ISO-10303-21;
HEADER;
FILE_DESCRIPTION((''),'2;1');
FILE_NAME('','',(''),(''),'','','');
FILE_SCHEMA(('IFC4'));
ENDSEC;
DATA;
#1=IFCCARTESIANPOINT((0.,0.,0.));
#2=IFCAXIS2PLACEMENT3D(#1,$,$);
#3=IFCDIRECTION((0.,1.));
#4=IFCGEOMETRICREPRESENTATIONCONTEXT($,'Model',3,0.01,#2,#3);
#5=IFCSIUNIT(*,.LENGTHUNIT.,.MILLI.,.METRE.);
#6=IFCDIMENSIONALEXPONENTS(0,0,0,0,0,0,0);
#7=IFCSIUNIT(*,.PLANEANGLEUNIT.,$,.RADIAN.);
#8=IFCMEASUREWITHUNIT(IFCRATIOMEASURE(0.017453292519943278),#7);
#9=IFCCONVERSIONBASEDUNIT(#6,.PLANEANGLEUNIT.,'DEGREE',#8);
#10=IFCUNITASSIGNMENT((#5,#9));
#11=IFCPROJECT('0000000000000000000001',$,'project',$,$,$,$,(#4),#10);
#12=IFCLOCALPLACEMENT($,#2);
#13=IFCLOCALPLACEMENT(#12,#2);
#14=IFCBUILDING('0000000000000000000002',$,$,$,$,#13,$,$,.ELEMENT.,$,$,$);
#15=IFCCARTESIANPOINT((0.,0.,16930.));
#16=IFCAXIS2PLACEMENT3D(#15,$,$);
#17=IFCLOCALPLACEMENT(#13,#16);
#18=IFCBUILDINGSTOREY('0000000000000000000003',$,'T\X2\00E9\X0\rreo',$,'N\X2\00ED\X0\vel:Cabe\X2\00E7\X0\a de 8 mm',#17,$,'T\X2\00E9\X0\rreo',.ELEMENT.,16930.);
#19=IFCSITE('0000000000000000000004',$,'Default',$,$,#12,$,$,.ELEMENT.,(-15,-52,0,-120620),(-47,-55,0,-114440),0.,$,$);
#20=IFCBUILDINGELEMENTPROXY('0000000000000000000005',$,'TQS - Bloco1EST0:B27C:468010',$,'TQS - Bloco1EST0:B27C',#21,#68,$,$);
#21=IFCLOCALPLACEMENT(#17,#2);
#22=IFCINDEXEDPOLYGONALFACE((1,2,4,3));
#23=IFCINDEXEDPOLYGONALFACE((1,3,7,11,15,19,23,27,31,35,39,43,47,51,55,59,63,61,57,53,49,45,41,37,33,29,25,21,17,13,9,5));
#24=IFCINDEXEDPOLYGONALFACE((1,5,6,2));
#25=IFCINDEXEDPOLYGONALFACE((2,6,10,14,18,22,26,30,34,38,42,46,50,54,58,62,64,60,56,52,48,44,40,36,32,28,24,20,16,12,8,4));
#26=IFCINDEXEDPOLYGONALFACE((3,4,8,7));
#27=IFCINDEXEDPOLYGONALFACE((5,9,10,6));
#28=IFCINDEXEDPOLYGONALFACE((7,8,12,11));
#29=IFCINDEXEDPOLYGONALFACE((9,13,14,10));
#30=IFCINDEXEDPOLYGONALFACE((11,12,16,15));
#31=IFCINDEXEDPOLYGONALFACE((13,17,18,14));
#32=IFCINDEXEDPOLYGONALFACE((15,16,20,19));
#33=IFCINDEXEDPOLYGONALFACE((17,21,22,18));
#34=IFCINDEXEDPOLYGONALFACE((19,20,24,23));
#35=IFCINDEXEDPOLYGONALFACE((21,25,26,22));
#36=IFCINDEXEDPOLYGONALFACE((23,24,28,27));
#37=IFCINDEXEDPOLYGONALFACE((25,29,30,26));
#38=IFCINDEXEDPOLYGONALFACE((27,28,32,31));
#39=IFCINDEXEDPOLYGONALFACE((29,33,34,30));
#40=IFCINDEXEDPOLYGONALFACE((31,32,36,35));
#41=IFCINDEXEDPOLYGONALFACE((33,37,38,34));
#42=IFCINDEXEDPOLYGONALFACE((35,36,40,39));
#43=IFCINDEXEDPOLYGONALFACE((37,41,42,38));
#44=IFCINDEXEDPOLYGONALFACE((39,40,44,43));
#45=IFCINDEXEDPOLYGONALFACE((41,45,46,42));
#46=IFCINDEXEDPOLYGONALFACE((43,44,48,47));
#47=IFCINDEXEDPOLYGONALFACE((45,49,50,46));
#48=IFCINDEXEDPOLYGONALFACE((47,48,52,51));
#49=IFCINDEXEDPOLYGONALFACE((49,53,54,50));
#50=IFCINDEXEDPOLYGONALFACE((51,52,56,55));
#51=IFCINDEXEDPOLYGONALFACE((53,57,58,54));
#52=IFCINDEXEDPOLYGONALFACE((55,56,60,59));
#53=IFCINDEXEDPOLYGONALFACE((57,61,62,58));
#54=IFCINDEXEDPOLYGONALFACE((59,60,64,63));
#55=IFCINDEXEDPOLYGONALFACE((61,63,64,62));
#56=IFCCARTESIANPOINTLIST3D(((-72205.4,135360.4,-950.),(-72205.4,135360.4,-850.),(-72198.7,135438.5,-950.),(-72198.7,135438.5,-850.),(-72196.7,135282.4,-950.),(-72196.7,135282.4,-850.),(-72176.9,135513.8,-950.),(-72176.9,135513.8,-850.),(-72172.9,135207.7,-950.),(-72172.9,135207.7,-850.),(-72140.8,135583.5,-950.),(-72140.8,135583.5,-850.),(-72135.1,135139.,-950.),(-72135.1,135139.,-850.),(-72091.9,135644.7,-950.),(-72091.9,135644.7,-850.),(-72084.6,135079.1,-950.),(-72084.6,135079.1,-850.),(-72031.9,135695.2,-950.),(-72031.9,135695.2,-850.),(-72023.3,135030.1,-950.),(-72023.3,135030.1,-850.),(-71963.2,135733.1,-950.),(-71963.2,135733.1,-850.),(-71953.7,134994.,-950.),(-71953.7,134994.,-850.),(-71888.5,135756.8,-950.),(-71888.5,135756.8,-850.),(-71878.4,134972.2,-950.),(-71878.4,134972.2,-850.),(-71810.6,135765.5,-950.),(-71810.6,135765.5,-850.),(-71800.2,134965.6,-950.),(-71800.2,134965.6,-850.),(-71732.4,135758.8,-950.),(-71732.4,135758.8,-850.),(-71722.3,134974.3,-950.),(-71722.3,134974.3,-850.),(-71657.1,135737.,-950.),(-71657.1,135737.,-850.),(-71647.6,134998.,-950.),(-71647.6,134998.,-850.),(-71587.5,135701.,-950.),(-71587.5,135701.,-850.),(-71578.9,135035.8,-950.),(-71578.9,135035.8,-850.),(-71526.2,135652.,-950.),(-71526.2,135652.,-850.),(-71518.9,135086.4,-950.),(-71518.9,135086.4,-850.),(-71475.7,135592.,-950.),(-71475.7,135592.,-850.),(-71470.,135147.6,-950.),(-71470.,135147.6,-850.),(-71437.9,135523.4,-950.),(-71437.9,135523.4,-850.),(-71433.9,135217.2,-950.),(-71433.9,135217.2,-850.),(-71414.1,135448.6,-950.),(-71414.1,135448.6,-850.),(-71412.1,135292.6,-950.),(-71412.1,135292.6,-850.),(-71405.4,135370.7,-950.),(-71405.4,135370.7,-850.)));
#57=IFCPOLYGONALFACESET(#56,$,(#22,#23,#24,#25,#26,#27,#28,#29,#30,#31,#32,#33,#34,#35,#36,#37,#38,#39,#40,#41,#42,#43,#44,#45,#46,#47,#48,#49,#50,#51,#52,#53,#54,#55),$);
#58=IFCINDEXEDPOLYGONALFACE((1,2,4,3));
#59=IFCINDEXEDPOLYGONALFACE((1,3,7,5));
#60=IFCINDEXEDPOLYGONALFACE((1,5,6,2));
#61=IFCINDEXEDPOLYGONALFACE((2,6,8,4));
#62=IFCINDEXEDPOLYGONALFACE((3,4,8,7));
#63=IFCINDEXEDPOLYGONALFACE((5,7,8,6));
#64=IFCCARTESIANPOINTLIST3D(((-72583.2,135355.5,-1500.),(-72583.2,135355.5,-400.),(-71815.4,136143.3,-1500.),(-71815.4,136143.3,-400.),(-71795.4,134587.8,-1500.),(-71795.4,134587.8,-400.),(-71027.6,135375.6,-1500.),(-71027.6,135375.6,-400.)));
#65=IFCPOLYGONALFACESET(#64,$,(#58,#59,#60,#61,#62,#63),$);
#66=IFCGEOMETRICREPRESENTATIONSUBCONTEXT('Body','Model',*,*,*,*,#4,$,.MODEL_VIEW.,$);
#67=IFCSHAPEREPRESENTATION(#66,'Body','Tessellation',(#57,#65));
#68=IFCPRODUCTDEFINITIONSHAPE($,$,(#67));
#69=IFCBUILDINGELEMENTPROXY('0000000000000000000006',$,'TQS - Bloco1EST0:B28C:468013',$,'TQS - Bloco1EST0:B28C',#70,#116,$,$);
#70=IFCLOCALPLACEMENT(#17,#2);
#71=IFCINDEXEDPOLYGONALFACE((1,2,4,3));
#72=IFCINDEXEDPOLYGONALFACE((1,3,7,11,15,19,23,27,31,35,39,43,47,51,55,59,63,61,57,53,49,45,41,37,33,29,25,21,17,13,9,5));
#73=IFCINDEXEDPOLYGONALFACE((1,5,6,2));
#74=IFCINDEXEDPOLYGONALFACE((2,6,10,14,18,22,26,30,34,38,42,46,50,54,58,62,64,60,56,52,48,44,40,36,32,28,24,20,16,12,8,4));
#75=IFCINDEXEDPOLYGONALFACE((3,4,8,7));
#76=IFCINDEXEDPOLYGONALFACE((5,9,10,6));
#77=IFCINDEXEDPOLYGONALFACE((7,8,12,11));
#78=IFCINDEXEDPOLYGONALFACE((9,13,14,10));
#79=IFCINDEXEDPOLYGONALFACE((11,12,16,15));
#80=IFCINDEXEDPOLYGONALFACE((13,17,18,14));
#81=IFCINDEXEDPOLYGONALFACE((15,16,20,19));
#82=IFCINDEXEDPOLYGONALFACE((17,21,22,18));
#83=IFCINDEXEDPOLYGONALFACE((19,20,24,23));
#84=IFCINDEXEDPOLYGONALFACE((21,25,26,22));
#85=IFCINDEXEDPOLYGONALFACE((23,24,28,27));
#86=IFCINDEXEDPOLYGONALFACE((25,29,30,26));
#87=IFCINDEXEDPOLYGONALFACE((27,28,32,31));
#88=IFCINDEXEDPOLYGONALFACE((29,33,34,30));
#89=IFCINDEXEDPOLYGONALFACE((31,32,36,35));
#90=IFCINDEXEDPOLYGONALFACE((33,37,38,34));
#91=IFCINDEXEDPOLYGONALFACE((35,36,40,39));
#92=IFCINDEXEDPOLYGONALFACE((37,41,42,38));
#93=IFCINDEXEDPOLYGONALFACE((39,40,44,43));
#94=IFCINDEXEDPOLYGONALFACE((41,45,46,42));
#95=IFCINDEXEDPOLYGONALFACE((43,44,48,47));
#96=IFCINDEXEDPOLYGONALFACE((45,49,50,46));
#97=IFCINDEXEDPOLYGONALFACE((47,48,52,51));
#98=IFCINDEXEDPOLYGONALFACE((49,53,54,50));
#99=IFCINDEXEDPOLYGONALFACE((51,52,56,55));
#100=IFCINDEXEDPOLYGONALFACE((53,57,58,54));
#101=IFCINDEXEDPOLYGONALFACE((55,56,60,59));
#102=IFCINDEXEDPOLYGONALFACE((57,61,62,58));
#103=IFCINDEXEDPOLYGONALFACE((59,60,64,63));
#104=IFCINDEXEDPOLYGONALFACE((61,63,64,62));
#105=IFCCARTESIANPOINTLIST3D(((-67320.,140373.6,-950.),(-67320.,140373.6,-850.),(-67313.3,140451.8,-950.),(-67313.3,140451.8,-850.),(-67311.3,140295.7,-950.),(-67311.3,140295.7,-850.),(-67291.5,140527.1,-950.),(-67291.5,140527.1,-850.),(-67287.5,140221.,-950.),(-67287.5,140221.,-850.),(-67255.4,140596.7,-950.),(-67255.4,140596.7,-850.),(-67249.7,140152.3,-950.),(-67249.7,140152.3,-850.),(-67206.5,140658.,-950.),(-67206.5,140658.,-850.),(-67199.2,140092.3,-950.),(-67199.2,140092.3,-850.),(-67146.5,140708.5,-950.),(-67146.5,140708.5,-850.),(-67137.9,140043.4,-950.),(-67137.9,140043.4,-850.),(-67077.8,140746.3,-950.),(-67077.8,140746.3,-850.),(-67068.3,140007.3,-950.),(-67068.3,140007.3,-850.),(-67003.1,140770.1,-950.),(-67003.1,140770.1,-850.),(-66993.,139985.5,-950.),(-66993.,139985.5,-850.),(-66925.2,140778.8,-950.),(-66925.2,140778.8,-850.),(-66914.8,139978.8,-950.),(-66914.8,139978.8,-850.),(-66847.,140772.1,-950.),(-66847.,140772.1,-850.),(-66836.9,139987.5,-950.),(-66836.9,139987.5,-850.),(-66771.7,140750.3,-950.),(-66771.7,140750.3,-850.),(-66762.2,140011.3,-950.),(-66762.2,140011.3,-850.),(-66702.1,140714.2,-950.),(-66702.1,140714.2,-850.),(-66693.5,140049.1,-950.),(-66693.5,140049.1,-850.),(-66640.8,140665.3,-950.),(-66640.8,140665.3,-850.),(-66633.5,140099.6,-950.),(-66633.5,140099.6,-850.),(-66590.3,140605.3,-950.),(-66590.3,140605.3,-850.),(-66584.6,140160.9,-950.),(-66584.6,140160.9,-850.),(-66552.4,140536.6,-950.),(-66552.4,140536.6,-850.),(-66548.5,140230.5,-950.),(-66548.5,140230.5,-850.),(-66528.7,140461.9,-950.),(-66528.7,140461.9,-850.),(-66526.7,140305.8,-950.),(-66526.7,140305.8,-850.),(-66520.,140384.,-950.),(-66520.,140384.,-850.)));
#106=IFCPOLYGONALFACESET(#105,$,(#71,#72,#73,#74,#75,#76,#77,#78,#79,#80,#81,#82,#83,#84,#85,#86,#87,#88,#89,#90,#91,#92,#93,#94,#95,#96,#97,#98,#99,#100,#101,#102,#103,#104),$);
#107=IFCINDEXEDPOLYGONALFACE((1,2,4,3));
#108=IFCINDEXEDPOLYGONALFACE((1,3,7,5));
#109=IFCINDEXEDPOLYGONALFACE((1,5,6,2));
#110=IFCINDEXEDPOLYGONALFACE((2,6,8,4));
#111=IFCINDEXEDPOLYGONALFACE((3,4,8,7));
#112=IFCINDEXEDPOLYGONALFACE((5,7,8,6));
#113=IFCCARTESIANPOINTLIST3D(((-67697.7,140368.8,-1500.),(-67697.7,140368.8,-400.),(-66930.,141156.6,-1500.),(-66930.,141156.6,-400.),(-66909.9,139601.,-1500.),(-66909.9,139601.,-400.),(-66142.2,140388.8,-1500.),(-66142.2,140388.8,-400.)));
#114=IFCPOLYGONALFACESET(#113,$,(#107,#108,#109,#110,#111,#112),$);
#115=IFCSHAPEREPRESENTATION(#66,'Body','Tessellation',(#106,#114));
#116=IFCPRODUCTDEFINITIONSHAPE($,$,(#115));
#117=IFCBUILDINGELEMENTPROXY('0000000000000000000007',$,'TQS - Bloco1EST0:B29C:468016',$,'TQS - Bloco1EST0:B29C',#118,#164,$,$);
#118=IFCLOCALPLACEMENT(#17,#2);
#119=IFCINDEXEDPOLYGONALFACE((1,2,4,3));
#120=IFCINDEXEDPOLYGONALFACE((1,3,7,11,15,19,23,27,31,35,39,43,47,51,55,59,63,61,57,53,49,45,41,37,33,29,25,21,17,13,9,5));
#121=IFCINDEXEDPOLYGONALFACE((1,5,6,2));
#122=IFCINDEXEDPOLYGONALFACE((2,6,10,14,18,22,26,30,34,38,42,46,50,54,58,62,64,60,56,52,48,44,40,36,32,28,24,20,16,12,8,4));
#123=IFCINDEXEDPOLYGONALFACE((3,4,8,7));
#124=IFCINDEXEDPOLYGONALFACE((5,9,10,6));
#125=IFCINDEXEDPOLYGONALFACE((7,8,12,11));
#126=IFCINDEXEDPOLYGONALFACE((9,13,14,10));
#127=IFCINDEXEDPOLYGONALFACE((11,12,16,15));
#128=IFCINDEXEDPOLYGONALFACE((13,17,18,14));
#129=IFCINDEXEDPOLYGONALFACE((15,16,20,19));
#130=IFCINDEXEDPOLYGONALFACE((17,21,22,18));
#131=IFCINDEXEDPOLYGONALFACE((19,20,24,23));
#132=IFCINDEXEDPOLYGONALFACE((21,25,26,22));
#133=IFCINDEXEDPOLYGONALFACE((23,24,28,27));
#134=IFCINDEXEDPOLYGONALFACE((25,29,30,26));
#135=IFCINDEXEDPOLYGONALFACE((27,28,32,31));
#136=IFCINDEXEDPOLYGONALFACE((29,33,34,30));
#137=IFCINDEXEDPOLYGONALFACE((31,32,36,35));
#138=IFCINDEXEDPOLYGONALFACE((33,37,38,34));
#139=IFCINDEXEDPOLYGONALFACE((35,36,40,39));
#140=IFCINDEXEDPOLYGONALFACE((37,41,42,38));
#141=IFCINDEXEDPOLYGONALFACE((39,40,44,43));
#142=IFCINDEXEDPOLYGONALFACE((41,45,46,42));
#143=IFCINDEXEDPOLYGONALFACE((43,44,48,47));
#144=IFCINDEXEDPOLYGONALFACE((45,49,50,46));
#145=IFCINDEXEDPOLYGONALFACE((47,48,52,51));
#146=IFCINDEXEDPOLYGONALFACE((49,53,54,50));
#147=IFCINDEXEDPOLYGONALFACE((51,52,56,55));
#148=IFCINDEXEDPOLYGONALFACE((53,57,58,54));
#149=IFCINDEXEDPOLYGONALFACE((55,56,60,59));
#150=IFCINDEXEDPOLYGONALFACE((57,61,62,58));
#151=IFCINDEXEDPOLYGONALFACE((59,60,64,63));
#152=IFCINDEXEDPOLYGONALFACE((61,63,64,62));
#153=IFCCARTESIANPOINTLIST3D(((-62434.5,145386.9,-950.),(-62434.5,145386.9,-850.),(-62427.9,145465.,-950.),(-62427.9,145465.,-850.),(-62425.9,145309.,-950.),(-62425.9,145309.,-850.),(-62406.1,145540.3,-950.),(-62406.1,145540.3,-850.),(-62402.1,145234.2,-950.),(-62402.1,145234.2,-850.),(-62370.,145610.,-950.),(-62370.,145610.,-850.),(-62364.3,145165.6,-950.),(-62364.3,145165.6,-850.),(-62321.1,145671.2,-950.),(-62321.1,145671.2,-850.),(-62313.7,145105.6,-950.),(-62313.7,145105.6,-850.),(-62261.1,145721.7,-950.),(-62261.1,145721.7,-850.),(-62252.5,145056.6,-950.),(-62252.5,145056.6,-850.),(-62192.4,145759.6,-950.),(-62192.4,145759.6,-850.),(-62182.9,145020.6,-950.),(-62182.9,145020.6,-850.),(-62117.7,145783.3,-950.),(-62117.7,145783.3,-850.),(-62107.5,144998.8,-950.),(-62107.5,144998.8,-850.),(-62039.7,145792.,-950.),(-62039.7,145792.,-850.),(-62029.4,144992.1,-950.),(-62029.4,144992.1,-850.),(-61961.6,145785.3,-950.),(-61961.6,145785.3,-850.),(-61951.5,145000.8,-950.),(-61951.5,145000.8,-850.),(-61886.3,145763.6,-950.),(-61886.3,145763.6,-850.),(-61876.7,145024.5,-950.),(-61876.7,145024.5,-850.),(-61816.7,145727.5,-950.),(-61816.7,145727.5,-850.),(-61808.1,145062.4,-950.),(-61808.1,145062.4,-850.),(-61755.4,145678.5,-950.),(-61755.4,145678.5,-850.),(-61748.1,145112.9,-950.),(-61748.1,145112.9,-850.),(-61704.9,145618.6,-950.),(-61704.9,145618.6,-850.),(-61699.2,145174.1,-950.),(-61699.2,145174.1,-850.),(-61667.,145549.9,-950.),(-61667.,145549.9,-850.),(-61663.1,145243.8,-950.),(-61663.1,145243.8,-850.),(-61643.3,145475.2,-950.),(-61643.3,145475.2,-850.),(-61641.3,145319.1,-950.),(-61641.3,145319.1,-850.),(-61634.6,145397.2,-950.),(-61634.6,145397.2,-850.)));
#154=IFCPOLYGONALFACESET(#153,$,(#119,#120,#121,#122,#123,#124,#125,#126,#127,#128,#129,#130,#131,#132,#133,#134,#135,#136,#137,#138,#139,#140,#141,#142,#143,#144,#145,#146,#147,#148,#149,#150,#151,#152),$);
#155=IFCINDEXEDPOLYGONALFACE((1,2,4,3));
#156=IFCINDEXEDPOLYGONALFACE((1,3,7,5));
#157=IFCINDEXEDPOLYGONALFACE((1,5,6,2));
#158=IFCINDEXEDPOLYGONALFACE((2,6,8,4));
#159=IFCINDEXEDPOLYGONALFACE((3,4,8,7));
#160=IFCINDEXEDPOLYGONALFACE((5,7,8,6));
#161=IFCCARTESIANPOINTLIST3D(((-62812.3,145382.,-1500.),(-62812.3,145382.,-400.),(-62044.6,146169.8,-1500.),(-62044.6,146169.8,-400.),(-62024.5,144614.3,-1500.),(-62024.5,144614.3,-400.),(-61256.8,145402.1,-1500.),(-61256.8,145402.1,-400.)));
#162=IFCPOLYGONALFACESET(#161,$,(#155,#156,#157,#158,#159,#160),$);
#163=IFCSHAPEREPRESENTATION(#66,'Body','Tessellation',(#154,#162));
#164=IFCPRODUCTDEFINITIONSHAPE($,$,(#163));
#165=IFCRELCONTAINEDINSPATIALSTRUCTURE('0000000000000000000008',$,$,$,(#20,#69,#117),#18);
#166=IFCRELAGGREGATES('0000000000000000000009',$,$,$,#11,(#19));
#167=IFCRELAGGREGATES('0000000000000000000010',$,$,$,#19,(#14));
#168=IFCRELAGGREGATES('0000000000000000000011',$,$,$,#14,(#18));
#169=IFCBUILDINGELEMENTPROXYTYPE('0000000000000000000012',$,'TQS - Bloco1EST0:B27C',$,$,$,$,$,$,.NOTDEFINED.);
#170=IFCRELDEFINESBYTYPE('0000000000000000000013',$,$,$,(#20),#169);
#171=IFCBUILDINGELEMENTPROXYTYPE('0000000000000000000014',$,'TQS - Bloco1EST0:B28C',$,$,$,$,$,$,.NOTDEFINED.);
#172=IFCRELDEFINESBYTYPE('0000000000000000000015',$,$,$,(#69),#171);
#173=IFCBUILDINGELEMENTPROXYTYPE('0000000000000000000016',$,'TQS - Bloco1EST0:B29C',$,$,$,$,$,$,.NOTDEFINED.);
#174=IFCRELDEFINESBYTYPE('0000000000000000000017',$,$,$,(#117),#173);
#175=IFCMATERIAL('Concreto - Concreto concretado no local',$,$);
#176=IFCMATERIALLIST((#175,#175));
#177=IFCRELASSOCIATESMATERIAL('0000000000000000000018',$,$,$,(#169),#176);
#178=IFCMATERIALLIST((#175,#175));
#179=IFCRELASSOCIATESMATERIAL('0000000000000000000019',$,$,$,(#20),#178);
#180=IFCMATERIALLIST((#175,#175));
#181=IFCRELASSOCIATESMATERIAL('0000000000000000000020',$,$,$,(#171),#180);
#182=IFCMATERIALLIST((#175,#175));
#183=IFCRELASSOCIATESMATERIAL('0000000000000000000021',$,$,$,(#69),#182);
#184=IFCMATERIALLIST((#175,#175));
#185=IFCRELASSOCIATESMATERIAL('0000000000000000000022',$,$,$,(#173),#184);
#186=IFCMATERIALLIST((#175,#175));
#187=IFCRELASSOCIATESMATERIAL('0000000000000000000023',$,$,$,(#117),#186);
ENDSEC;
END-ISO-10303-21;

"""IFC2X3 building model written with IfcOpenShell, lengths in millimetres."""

from ifc_helpers import new_model, entity, si_unit, converted_unit, direction, frame, frame_2d, origin, origin_2d_with_axis, place, context, subcontext, project, spatial, rectangle, circle, extrude, source, transform, mapped, material, material_list, type_object, type_shapes, element, save


model = new_model("IFC2X3")

# Units and contexts
model_context = context("Model", 3, precision=0.01, world=origin(), true_north=direction((0.0, 1.0)))
body_context = subcontext(model_context, "Body", "Model", "MODEL_VIEW")
ifc_project = project(units=[si_unit("LENGTHUNIT", "METRE", prefix="MILLI"), converted_unit("PLANEANGLEUNIT", "DEGREE", entity("IfcRatioMeasure", 0.017453292519943278), si_unit("PLANEANGLEUNIT", "RADIAN"), dimensions=[0, 0, 0, 0, 0, 0, 0])], contexts=[model_context])

# Site, building, storey
site_placement = place(None, origin())
site = spatial("IfcSite", under=ifc_project, at=site_placement, Name="Default", CompositionType="ELEMENT", RefLatitude=(-15, -52, 0, -120620), RefLongitude=(-47, -55, 0, -114440), RefElevation=0.0)
building_placement = place(site_placement, origin())
building = spatial("IfcBuilding", under=site, at=building_placement, CompositionType="ELEMENT")
storey_placement = place(building_placement, frame((0.0, 0.0, 16930.0)))
storey = spatial("IfcBuildingStorey", under=building, at=storey_placement, Name="Térreo", ObjectType="Nível:Cabeça de 8 mm", LongName="Térreo", CompositionType="ELEMENT", Elevation=16930.0)

# Building element proxies
ifc_material_1 = material(Name="Concreto - Concreto concretado no local")
ifc_material_list_1 = material_list([ifc_material_1, ifc_material_1])
ifc_material_list_2 = material_list([ifc_material_1, ifc_material_1])
building_element_proxy_type_1 = type_object("IfcBuildingElementProxyType", Name="TQS - Bloco1EST0:B27C", PredefinedType="NOTDEFINED", material=ifc_material_list_2)
shared_shape_1 = source(origin(), body_context, "Body", "SweptSolid", [
    extrude(circle(Radius=400.0, at=frame_2d((0.0, 0.0), x_axis=(1.0, 0.0))), frame((0.0, 0.0, -550.0)), (0.0, 0.0, 1.0), 100.0),
    extrude(rectangle(XDim=1100.0, YDim=1100.0, at=origin_2d_with_axis()), frame((0.0, 0.0, -1100.0), z_axis=(0.0, 0.0, 1.0), x_axis=(-1.0, 0.0, 0.0)), (0.0, 0.0, 1.0), 1100.0),
])
type_shapes(building_element_proxy_type_1, [shared_shape_1])
proxy_1_placement = place(storey_placement, frame((-71805.4, 135365.5, -400.0), z_axis=(0.0, 0.0, 1.0), x_axis=(0.697915, 0.71618, 0.0)))
element("IfcBuildingElementProxy", 1, at=proxy_1_placement, inside=storey, type_object=building_element_proxy_type_1, material=ifc_material_list_1, Name="TQS - Bloco1EST0:B27C:468010", ObjectType="TQS - Bloco1EST0:B27C", context=body_context, shape_type="MappedRepresentation", body=[
    mapped(shared_shape_1, transform((0.0, 0.0, 0.0), scale=1.0)),
])
ifc_material_list_3 = material_list([ifc_material_1, ifc_material_1])
ifc_material_list_4 = material_list([ifc_material_1, ifc_material_1])
building_element_proxy_type_2 = type_object("IfcBuildingElementProxyType", Name="TQS - Bloco1EST0:B28C", PredefinedType="NOTDEFINED", material=ifc_material_list_4)
shared_shape_2 = source(origin(), body_context, "Body", "SweptSolid", [
    extrude(circle(Radius=400.0, at=frame_2d((0.0, 0.0), x_axis=(1.0, 0.0))), frame((0.0, 0.0, -550.0)), (0.0, 0.0, 1.0), 100.0),
    extrude(rectangle(XDim=1100.0, YDim=1100.0, at=origin_2d_with_axis()), frame((0.0, 0.0, -1100.0), z_axis=(0.0, 0.0, 1.0), x_axis=(-1.0, 0.0, 0.0)), (0.0, 0.0, 1.0), 1100.0),
])
type_shapes(building_element_proxy_type_2, [shared_shape_2])
proxy_2_placement = place(storey_placement, frame((-66920.0, 140378.8, -400.0), z_axis=(0.0, 0.0, 1.0), x_axis=(0.697915, 0.71618, 0.0)))
element("IfcBuildingElementProxy", 2, at=proxy_2_placement, inside=storey, type_object=building_element_proxy_type_2, material=ifc_material_list_3, Name="TQS - Bloco1EST0:B28C:468013", ObjectType="TQS - Bloco1EST0:B28C", context=body_context, shape_type="MappedRepresentation", body=[
    mapped(shared_shape_2, transform((0.0, 0.0, 0.0), scale=1.0)),
])
ifc_material_list_5 = material_list([ifc_material_1, ifc_material_1])
ifc_material_list_6 = material_list([ifc_material_1, ifc_material_1])
building_element_proxy_type_3 = type_object("IfcBuildingElementProxyType", Name="TQS - Bloco1EST0:B29C", PredefinedType="NOTDEFINED", material=ifc_material_list_6)
shared_shape_3 = source(origin(), body_context, "Body", "SweptSolid", [
    extrude(circle(Radius=400.0, at=frame_2d((0.0, 0.0), x_axis=(1.0, 0.0))), frame((0.0, 0.0, -550.0)), (0.0, 0.0, 1.0), 100.0),
    extrude(rectangle(XDim=1100.0, YDim=1100.0, at=origin_2d_with_axis()), frame((0.0, 0.0, -1100.0), z_axis=(0.0, 0.0, 1.0), x_axis=(-1.0, 0.0, 0.0)), (0.0, 0.0, 1.0), 1100.0),
])
type_shapes(building_element_proxy_type_3, [shared_shape_3])
proxy_3_placement = place(storey_placement, frame((-62034.6, 145392.1, -400.0), z_axis=(0.0, 0.0, 1.0), x_axis=(0.697915, 0.71618, 0.0)))
element("IfcBuildingElementProxy", 3, at=proxy_3_placement, inside=storey, type_object=building_element_proxy_type_3, material=ifc_material_list_5, Name="TQS - Bloco1EST0:B29C:468016", ObjectType="TQS - Bloco1EST0:B29C", context=body_context, shape_type="MappedRepresentation", body=[
    mapped(shared_shape_3, transform((0.0, 0.0, 0.0), scale=1.0)),
])

save(model, "model.ifc")
